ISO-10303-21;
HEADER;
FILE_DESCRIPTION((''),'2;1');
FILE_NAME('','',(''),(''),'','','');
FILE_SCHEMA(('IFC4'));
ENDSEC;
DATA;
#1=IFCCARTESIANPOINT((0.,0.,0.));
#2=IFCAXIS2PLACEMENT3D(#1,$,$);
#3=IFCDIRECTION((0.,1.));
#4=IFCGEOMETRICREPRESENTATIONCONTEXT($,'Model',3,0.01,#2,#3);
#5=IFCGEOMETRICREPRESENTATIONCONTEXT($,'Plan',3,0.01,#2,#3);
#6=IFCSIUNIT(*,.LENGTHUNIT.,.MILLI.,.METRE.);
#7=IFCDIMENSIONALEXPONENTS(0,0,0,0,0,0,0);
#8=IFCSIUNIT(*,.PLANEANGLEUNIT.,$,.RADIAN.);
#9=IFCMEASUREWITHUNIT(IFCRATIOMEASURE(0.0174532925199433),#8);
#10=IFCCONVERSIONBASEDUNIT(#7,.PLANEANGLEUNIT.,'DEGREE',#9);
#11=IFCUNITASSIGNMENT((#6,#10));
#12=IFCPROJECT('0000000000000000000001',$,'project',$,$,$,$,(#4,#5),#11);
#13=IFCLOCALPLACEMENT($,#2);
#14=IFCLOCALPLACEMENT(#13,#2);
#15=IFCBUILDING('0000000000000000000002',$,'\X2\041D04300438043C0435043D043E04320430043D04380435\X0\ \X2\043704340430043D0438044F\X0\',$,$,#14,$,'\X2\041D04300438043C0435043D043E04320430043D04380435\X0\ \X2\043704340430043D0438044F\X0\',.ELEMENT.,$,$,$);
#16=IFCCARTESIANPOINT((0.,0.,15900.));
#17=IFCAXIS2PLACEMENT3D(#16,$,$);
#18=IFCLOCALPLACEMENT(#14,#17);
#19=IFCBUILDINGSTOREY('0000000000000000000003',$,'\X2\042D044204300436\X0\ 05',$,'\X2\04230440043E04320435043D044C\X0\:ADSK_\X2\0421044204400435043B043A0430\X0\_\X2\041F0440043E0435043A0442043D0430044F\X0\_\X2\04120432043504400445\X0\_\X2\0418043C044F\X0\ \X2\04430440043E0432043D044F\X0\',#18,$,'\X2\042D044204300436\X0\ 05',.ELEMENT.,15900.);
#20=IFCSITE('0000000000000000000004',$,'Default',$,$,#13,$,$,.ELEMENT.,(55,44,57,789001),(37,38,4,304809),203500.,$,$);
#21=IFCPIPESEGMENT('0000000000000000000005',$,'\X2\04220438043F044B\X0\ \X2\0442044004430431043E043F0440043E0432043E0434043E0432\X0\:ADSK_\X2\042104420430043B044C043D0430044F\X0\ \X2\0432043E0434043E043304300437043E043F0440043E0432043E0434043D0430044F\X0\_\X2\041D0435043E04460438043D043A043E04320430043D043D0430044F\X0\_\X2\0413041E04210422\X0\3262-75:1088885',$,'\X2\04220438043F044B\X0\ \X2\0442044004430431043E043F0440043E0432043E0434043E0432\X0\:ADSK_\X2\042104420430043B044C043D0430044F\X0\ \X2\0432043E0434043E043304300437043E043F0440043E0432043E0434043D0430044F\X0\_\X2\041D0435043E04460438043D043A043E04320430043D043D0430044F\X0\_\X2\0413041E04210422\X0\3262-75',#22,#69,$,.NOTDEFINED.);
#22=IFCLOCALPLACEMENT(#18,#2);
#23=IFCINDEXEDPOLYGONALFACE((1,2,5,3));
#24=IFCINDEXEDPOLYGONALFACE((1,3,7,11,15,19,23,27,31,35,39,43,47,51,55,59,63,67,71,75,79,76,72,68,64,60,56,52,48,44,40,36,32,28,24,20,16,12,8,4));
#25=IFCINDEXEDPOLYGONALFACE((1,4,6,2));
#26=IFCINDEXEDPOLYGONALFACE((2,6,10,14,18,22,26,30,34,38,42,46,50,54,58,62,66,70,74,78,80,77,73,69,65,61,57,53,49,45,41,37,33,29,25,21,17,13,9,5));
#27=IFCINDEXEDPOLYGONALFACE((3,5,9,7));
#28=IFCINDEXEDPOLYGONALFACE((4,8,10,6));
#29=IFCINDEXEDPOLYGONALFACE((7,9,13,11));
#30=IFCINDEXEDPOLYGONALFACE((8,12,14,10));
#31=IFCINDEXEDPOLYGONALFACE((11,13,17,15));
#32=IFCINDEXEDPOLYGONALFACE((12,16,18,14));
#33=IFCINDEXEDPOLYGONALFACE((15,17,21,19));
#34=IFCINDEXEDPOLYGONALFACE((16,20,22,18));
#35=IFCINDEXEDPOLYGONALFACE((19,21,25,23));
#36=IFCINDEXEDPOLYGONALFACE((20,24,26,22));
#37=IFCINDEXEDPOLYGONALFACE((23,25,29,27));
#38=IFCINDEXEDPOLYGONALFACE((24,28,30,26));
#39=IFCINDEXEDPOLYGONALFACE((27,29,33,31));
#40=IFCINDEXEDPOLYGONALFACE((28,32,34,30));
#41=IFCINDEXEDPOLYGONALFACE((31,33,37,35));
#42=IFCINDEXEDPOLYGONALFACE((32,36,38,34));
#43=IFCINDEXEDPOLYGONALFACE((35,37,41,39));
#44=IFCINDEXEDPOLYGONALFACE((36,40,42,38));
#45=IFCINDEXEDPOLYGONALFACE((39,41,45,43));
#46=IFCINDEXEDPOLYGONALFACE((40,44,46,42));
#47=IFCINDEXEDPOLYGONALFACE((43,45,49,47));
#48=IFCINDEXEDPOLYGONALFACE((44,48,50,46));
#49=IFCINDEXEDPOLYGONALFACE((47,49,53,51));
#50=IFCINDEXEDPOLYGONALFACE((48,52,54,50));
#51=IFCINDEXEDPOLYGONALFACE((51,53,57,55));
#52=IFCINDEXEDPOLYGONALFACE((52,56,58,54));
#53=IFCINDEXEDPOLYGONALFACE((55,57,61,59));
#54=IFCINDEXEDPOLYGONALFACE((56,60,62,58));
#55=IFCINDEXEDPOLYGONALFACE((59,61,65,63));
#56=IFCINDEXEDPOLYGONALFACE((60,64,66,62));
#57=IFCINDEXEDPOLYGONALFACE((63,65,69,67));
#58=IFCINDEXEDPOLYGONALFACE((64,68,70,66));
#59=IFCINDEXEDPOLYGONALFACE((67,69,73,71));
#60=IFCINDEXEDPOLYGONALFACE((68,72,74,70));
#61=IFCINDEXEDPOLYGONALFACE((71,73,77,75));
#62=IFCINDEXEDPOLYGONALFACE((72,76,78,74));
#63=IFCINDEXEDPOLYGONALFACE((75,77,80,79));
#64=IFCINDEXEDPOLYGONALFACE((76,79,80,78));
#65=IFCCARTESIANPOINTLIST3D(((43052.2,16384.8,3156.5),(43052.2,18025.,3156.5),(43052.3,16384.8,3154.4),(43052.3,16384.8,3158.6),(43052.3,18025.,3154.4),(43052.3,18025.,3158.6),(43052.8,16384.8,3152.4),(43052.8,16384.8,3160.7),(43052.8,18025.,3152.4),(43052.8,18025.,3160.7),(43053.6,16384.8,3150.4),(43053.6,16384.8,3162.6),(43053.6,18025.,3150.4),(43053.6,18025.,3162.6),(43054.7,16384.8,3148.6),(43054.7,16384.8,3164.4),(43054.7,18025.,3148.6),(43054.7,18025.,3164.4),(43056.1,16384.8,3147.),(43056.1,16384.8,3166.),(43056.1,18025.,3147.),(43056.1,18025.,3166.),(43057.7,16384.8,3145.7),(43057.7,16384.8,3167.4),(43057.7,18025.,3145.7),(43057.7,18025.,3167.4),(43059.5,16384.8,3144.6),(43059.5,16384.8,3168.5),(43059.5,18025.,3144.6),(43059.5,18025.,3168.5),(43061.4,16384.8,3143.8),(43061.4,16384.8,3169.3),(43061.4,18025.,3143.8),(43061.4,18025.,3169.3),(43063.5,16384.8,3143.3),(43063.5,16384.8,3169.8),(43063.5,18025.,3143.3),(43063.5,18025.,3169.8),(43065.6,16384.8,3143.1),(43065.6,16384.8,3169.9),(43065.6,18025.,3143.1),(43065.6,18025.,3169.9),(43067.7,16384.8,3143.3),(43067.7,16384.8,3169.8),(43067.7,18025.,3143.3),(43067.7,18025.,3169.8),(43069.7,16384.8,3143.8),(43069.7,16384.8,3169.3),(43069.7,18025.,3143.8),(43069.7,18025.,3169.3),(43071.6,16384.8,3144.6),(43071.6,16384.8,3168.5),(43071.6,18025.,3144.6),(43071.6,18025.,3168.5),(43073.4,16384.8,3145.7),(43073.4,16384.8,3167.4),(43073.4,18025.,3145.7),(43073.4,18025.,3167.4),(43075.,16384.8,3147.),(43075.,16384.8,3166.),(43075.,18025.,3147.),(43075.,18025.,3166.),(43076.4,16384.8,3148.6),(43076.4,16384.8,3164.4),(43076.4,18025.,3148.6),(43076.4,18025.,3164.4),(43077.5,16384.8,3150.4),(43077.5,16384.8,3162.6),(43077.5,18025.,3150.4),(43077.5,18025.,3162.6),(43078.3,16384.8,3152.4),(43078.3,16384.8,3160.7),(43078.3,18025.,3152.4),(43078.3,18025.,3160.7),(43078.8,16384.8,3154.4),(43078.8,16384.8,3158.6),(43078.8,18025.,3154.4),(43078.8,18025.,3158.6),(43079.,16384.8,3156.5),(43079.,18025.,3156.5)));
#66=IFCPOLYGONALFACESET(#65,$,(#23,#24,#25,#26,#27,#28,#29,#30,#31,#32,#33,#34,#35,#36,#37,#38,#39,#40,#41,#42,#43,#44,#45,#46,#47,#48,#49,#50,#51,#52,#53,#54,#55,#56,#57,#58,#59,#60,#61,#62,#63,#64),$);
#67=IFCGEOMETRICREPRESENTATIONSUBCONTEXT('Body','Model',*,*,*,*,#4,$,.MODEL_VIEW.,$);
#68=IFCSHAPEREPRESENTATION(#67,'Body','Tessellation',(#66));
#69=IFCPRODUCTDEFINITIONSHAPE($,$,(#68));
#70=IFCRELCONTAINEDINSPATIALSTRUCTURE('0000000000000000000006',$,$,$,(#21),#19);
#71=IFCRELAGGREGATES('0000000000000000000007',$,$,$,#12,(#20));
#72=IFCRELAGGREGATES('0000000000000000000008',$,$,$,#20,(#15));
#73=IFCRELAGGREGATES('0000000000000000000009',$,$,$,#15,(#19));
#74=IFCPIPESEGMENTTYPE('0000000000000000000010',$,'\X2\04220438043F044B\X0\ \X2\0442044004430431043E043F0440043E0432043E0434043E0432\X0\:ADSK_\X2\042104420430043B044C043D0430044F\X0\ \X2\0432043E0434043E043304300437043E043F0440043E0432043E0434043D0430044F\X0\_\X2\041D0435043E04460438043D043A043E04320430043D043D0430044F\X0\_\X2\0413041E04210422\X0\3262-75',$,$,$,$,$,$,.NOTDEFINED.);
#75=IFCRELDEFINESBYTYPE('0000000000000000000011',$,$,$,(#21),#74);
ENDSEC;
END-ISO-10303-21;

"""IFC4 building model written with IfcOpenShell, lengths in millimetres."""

from ifc_helpers import new_model, entity, si_unit, converted_unit, direction, frame, origin, place, context, subcontext, project, spatial, indexed_curve, outline, extrude, type_object, element, save


model = new_model("IFC4")

# Units and contexts
model_context = context("Model", 3, precision=0.01, world=origin(), true_north=direction((0.0, 1.0)))
plan_context = context("Plan", 3, precision=0.01, world=origin(), true_north=direction((0.0, 1.0)))
body_context = subcontext(model_context, "Body", "Model", "MODEL_VIEW")
ifc_project = project(units=[si_unit("LENGTHUNIT", "METRE", prefix="MILLI"), converted_unit("PLANEANGLEUNIT", "DEGREE", entity("IfcRatioMeasure", 0.0174532925199433), si_unit("PLANEANGLEUNIT", "RADIAN"), dimensions=[0, 0, 0, 0, 0, 0, 0])], contexts=[model_context, plan_context])

# Site, building, storey
site_placement = place(None, origin())
site = spatial("IfcSite", under=ifc_project, at=site_placement, Name="Default", CompositionType="ELEMENT", RefLatitude=(55, 44, 57, 789001), RefLongitude=(37, 38, 4, 304809), RefElevation=203500.0)
building_placement = place(site_placement, origin())
building = spatial("IfcBuilding", under=site, at=building_placement, Name="Наименование здания", LongName="Наименование здания", CompositionType="ELEMENT")
storey_placement = place(building_placement, frame((0.0, 0.0, 15900.0)))
storey = spatial("IfcBuildingStorey", under=building, at=storey_placement, Name="Этаж 05", ObjectType="Уровень:ADSK_Стрелка_Проектная_Вверх_Имя уровня", LongName="Этаж 05", CompositionType="ELEMENT", Elevation=15900.0)

# Pipe segment
placement = place(storey_placement, origin())
pipe_segment_type_1 = type_object("IfcPipeSegmentType", Name="Типы трубопроводов:ADSK_Стальная водогазопроводная_Неоцинкованная_ГОСТ3262-75", PredefinedType="NOTDEFINED")
element("IfcPipeSegment", 1, at=placement, inside=storey, type_object=pipe_segment_type_1, Name="Типы трубопроводов:ADSK_Стальная водогазопроводная_Неоцинкованная_ГОСТ3262-75:1088885", ObjectType="Типы трубопроводов:ADSK_Стальная водогазопроводная_Неоцинкованная_ГОСТ3262-75", PredefinedType="NOTDEFINED", context=body_context, shape_type="SweptSolid", body=[
    extrude(outline(indexed_curve([(13.4, 0.0), (13.2, 2.1), (12.7, 4.1), (11.9, 6.1), (10.8, 7.9), (9.5, 9.5), (7.9, 10.8), (6.1, 11.9), (4.1, 12.7), (2.1, 13.2), (0.0, 13.4), (-2.1, 13.2), (-4.1, 12.7), (-6.1, 11.9), (-7.9, 10.8), (-9.5, 9.5), (-10.8, 7.9), (-11.9, 6.1), (-12.7, 4.1), (-13.2, 2.1), (-13.4, 0.0), (-13.2, -2.1), (-12.7, -4.1), (-11.9, -6.1), (-10.8, -7.9), (-9.5, -9.5), (-7.9, -10.8), (-6.1, -11.9), (-4.1, -12.7), (-2.1, -13.2), (0.0, -13.4), (2.1, -13.2), (4.1, -12.7), (6.1, -11.9), (7.9, -10.8), (9.5, -9.5), (10.8, -7.9), (11.9, -6.1), (12.7, -4.1), (13.2, -2.1), (13.4, 0.0)], self_intersect=False)), frame((43065.6, 16384.8, 3156.5), z_axis=(0.0, 1.0, 0.0), x_axis=(-1.0, 0.0, 0.0)), (0.0, 0.0, 1.0), 1640.2),
])

save(model, "model.ifc")
